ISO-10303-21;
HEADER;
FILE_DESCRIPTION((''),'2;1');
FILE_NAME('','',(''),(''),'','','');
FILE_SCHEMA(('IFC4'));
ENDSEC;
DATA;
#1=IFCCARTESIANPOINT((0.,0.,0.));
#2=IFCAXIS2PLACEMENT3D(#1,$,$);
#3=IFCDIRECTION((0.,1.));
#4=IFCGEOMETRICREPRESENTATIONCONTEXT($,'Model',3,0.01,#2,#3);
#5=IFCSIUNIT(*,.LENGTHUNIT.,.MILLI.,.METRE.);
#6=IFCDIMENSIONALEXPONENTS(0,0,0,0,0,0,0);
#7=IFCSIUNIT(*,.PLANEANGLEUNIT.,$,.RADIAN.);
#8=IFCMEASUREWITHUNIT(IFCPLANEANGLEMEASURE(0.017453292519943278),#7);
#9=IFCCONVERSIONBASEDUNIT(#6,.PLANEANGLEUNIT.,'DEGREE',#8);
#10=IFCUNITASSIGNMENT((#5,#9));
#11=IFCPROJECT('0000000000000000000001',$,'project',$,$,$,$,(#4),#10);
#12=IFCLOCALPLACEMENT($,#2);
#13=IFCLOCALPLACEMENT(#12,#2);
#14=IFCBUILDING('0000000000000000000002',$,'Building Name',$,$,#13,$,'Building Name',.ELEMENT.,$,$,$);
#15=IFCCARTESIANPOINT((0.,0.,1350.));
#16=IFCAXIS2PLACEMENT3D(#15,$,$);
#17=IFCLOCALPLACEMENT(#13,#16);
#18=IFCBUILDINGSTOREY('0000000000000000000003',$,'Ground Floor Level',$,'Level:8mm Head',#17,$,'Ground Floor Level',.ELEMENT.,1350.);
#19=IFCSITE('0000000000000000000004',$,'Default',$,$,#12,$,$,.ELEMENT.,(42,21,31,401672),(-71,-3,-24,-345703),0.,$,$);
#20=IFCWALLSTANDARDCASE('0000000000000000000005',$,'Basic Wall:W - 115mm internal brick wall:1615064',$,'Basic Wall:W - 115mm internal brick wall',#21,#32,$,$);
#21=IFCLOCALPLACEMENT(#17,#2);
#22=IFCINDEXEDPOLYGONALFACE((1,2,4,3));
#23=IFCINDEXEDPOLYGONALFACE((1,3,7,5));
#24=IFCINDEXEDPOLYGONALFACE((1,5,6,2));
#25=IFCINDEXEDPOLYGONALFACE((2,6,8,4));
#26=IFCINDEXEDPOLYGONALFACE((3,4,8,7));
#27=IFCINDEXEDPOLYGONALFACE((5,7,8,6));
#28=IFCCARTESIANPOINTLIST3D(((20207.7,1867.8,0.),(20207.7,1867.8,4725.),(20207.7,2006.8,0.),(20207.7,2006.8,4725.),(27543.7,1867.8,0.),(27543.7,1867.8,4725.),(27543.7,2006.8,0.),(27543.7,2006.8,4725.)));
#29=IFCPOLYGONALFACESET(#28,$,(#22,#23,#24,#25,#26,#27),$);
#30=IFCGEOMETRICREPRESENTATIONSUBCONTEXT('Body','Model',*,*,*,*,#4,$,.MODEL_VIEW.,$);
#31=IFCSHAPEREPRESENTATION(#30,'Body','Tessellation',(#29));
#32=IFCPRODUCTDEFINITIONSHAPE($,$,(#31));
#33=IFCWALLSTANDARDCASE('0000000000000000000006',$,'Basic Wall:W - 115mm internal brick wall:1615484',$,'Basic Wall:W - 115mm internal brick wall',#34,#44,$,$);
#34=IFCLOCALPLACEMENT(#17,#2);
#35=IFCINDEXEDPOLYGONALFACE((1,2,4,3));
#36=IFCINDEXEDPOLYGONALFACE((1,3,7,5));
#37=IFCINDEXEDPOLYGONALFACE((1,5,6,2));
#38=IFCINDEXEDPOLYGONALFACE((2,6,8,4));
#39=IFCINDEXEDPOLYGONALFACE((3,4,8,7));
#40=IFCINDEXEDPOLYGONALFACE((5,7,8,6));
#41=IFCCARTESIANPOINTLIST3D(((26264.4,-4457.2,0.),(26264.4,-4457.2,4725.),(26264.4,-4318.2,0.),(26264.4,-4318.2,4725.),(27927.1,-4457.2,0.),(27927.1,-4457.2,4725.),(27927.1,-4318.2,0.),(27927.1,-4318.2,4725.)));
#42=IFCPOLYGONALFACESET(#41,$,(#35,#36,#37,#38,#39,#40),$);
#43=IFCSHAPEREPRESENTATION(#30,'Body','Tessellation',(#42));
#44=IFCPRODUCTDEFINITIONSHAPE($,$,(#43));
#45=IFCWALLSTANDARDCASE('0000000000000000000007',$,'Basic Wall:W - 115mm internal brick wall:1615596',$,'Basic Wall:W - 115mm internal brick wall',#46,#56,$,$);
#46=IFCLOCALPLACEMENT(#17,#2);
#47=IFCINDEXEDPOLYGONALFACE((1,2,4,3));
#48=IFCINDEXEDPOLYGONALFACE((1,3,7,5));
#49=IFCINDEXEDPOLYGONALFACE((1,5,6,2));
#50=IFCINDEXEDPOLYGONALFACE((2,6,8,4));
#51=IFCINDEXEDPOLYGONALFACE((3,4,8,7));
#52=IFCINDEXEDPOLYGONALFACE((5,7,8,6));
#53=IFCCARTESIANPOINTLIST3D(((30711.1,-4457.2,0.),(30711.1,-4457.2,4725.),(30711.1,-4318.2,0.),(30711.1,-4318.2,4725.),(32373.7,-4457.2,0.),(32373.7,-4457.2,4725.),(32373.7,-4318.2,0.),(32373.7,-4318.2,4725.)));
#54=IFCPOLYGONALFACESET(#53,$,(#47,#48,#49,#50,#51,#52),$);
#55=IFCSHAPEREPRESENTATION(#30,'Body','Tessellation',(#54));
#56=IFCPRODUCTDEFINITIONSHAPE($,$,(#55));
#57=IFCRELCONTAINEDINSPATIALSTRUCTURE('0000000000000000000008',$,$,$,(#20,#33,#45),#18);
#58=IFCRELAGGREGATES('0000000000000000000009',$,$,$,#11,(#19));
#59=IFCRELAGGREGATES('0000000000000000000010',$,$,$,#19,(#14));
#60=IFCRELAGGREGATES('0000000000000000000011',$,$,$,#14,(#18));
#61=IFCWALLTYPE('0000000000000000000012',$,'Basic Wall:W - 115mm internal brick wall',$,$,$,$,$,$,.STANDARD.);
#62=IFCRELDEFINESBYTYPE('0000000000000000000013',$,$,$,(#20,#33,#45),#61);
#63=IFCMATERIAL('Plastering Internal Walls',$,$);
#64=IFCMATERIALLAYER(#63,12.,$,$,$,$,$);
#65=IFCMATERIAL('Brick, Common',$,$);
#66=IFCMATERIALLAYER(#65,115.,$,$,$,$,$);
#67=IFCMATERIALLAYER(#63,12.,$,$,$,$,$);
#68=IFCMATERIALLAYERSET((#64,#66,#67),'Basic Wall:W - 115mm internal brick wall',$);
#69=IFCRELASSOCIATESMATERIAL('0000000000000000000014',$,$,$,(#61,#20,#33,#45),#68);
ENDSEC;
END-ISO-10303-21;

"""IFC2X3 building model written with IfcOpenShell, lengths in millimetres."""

from ifc_helpers import new_model, entity, si_unit, converted_unit, direction, frame, frame_2d, origin, place, context, subcontext, project, spatial, rectangle, extrude, material, layer, layer_set, layer_usage, type_object, element, save


model = new_model("IFC2X3")

# Units and contexts
model_context = context("Model", 3, precision=0.01, world=origin(), true_north=direction((0.0, 1.0)))
body_context = subcontext(model_context, "Body", "Model", "MODEL_VIEW")
ifc_project = project(units=[si_unit("LENGTHUNIT", "METRE", prefix="MILLI"), converted_unit("PLANEANGLEUNIT", "DEGREE", entity("IfcPlaneAngleMeasure", 0.017453292519943278), si_unit("PLANEANGLEUNIT", "RADIAN"), dimensions=[0, 0, 0, 0, 0, 0, 0])], contexts=[model_context])

# Site, building, storey
site_placement = place(None, origin())
site = spatial("IfcSite", under=ifc_project, at=site_placement, Name="Default", CompositionType="ELEMENT", RefLatitude=(42, 21, 31, 401672), RefLongitude=(-71, -3, -24, -345703), RefElevation=0.0)
building_placement = place(site_placement, origin())
building = spatial("IfcBuilding", under=site, at=building_placement, Name="Building Name", LongName="Building Name", CompositionType="ELEMENT")
storey_placement = place(building_placement, frame((0.0, 0.0, 1350.0)))
storey = spatial("IfcBuildingStorey", under=building, at=storey_placement, Name="Ground Floor Level", ObjectType="Level:8mm Head", LongName="Ground Floor Level", CompositionType="ELEMENT", Elevation=1350.0)

# Walls
ifc_material_1 = material(Name="Brick, Common")
ifc_material_2 = material(Name="Plastering Internal Walls")
ifc_layer_1 = layer(ifc_material_2, 12.0)
ifc_layer_2 = layer(ifc_material_1, 115.0)
ifc_layer_3 = layer(ifc_material_2, 12.0)
ifc_layer_set_1 = layer_set([ifc_layer_1, ifc_layer_2, ifc_layer_3], Name="Basic Wall:W - 115mm internal brick wall")
wall_type_1 = type_object("IfcWallType", Name="Basic Wall:W - 115mm internal brick wall", PredefinedType="STANDARD", material=ifc_layer_set_1)
ifc_layer_usage_1 = layer_usage(ifc_layer_set_1, "AXIS2", "NEGATIVE", 69.5)
wall_1_placement = place(storey_placement, frame((27543.7, 1937.3, 0.0), z_axis=(0.0, 0.0, 1.0), x_axis=(-1.0, 0.0, 0.0)))
element("IfcWallStandardCase", 1, at=wall_1_placement, inside=storey, type_object=wall_type_1, material=ifc_layer_usage_1, Name="Basic Wall:W - 115mm internal brick wall:1615064", ObjectType="Basic Wall:W - 115mm internal brick wall", context=body_context, shape_type="SweptSolid", body=[
    extrude(rectangle(XDim=7336.0, YDim=139.0, at=frame_2d((3668.0, 0.0), x_axis=(-1.0, 0.0))), origin(), (0.0, 0.0, 1.0), 4725.0),
])
ifc_layer_usage_2 = layer_usage(ifc_layer_set_1, "AXIS2", "NEGATIVE", 69.5)
wall_2_placement = place(storey_placement, frame((27927.1, -4387.7, 0.0), z_axis=(0.0, 0.0, 1.0), x_axis=(-1.0, 0.0, 0.0)))
element("IfcWallStandardCase", 2, at=wall_2_placement, inside=storey, type_object=wall_type_1, material=ifc_layer_usage_2, Name="Basic Wall:W - 115mm internal brick wall:1615484", ObjectType="Basic Wall:W - 115mm internal brick wall", context=body_context, shape_type="SweptSolid", body=[
    extrude(rectangle(XDim=1662.7, YDim=139.0, at=frame_2d((831.3, 0.0), x_axis=(-1.0, 0.0))), origin(), (0.0, 0.0, 1.0), 4725.0),
])
ifc_layer_usage_3 = layer_usage(ifc_layer_set_1, "AXIS2", "NEGATIVE", 69.5)
wall_3_placement = place(storey_placement, frame((32373.7, -4387.7, 0.0), z_axis=(0.0, 0.0, 1.0), x_axis=(-1.0, 0.0, 0.0)))
element("IfcWallStandardCase", 3, at=wall_3_placement, inside=storey, type_object=wall_type_1, material=ifc_layer_usage_3, Name="Basic Wall:W - 115mm internal brick wall:1615596", ObjectType="Basic Wall:W - 115mm internal brick wall", context=body_context, shape_type="SweptSolid", body=[
    extrude(rectangle(XDim=1662.7, YDim=139.0, at=frame_2d((831.3, 0.0), x_axis=(-1.0, 0.0))), origin(), (0.0, 0.0, 1.0), 4725.0),
])

save(model, "model.ifc")
